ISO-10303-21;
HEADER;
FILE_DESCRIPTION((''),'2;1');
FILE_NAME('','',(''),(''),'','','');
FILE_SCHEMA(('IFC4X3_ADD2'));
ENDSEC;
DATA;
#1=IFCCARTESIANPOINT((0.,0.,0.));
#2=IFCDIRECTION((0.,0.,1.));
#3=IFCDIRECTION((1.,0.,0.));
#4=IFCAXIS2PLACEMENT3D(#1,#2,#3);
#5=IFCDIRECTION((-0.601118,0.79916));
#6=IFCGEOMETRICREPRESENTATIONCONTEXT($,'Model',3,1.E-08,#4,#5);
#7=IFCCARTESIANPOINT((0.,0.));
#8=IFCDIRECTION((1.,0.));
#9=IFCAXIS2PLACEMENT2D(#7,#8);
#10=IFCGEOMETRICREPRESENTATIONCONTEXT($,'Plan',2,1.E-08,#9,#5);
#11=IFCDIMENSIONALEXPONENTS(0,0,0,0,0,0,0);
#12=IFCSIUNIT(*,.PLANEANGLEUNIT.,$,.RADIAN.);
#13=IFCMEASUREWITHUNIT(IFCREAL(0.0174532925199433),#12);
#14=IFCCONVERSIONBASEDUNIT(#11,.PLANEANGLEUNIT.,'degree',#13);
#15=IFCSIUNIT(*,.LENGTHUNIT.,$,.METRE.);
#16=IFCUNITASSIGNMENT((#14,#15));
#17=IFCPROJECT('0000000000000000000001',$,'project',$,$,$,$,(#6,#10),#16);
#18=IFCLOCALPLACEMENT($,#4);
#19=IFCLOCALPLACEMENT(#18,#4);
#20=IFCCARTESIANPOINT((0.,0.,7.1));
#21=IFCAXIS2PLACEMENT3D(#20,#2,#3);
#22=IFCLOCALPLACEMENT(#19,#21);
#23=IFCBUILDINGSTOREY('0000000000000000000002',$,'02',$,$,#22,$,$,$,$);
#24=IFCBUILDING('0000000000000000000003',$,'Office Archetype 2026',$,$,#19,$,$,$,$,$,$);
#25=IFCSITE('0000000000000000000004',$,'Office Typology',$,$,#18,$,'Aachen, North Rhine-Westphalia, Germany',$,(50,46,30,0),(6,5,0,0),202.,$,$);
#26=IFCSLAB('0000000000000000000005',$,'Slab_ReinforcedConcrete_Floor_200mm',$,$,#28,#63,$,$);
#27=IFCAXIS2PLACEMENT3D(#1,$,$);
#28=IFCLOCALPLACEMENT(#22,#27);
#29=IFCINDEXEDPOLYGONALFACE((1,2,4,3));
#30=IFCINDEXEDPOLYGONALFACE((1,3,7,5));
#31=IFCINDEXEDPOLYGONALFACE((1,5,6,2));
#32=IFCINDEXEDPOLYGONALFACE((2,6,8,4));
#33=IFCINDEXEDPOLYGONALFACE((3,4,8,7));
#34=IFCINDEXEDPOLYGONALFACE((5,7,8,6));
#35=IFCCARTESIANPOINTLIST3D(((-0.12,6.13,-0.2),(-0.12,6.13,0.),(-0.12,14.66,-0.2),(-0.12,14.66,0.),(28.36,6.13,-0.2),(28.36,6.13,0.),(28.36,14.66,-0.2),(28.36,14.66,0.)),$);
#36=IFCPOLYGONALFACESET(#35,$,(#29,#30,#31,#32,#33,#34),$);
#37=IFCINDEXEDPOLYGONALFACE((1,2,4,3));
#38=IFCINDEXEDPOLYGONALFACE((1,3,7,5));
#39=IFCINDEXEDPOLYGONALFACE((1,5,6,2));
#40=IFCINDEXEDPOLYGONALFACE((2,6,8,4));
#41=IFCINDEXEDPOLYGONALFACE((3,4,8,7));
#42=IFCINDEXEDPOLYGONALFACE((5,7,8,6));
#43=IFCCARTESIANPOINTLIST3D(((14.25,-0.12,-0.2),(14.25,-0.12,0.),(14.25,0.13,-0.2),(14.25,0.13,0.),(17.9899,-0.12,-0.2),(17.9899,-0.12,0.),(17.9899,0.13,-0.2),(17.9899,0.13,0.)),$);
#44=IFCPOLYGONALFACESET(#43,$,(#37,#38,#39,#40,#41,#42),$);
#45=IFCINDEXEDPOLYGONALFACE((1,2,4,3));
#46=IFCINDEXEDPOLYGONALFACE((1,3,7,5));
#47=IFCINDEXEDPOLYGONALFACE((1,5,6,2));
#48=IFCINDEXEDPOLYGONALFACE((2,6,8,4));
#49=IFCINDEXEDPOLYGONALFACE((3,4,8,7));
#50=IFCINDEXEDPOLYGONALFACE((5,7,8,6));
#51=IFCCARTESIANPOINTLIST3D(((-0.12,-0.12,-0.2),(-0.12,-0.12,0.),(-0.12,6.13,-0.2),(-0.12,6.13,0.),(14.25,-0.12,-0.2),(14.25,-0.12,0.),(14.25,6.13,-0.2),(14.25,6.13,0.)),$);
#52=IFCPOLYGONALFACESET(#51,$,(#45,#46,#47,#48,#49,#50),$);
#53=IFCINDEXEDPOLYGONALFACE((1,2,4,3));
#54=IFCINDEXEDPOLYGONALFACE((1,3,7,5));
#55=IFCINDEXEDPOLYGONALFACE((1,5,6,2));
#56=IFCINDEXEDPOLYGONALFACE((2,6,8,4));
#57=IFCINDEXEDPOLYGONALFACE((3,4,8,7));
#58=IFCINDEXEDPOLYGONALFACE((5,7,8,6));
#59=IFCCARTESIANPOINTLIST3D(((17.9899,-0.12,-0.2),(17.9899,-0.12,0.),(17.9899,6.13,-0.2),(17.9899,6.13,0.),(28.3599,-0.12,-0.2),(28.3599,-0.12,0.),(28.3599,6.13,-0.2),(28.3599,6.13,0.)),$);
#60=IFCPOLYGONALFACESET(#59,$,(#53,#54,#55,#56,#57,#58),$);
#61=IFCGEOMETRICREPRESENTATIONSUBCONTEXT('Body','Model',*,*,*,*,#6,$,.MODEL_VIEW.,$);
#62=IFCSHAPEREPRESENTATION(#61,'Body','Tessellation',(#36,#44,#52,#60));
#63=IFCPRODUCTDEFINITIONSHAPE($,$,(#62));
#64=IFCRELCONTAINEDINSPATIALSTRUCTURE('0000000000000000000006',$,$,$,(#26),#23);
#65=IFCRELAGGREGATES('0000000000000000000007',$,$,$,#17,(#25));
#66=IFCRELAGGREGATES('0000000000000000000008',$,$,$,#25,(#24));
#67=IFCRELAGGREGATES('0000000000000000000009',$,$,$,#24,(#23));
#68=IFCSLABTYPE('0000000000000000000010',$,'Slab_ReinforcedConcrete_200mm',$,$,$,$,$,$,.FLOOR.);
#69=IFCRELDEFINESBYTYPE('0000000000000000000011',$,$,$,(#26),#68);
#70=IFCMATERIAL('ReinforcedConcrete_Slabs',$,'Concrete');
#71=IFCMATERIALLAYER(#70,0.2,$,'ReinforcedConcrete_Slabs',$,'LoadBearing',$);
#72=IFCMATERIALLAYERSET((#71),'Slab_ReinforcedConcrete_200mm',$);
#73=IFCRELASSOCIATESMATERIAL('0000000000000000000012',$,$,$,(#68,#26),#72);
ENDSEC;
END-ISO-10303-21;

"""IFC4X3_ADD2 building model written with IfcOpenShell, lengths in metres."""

from ifc_helpers import new_model, entity, si_unit, converted_unit, direction, frame, origin_with_axes, origin_2d_with_axis, place, context, subcontext, project, spatial, indexed_curve, outline, extrude, material, layer, layer_set, layer_usage, type_object, element, save


model = new_model("IFC4X3_ADD2")

# Units and contexts
model_context = context("Model", 3, precision=1e-08, world=origin_with_axes(), true_north=direction((-0.601118, 0.79916)))
plan_context = context("Plan", 2, precision=1e-08, world=origin_2d_with_axis(), true_north=direction((-0.601118, 0.79916)))
body_context = subcontext(model_context, "Body", "Model", "MODEL_VIEW")
ifc_project = project(units=[converted_unit("PLANEANGLEUNIT", "degree", entity("IfcReal", 0.0174532925199433), si_unit("PLANEANGLEUNIT", "RADIAN"), dimensions=[0, 0, 0, 0, 0, 0, 0]), si_unit("LENGTHUNIT", "METRE")], contexts=[model_context, plan_context])

# Site, building, storey
site_placement = place(None, origin_with_axes())
site = spatial("IfcSite", under=ifc_project, at=site_placement, Name="Office Typology", LongName="Aachen, North Rhine-Westphalia, Germany", RefLatitude=(50, 46, 30, 0), RefLongitude=(6, 5, 0, 0), RefElevation=202.0)
building_placement = place(site_placement, origin_with_axes())
building = spatial("IfcBuilding", under=site, at=building_placement, Name="Office Archetype 2026")
storey_placement = place(building_placement, frame((0.0, 0.0, 7.1), z_axis=(0.0, 0.0, 1.0), x_axis=(1.0, 0.0, 0.0)))
storey = spatial("IfcBuildingStorey", under=building, at=storey_placement, Name="02")

# Slab
ifc_material_1 = material(Name="ReinforcedConcrete_Slabs", Category="Concrete")
ifc_layer_1 = layer(ifc_material_1, 0.2, Name="ReinforcedConcrete_Slabs", Category="LoadBearing")
ifc_layer_set_1 = layer_set([ifc_layer_1], Name="Slab_ReinforcedConcrete_200mm")
slab_type_1 = type_object("IfcSlabType", Name="Slab_ReinforcedConcrete_200mm", PredefinedType="FLOOR", material=ifc_layer_set_1)
ifc_layer_usage_1 = layer_usage(ifc_layer_set_1, "AXIS3", "POSITIVE", 0.0)
slab_1_placement = place(storey_placement, frame((17.9899, 6.13, 0.0), z_axis=(0.0, 0.0, 1.0), x_axis=(1.0, 0.0, 0.0)))
element("IfcSlab", 1, at=slab_1_placement, inside=storey, type_object=slab_type_1, material=ifc_layer_usage_1, Name="Slab_ReinforcedConcrete_Floor_200mm", context=body_context, shape_type="SweptSolid", body=[
    extrude(outline(indexed_curve([(0.0, 0.0), (28.48, 0.0), (28.48, -8.53), (0.0, -8.53), (0.0, 0.0)])), frame((-18.1099, 8.53, -0.2), z_axis=(0.0, 0.0, 1.0), x_axis=(1.0, 0.0, 0.0)), (0.0, 0.0, 1.0), 0.2),
    extrude(outline(indexed_curve([(0.0, 0.0), (3.7399, 0.0), (3.7399, 0.25), (0.0, 0.25), (0.0, 0.0)])), frame((-3.7399, -6.25, -0.2), z_axis=(0.0, 0.0, 1.0), x_axis=(1.0, 0.0, 0.0)), (0.0, 0.0, 1.0), 0.2),
    extrude(outline(indexed_curve([(0.0, 0.0), (14.37, 0.0), (14.37, -6.25), (0.0, -6.25), (0.0, 0.0)])), frame((-18.1099, 0.0, -0.2), z_axis=(0.0, 0.0, 1.0), x_axis=(1.0, 0.0, 0.0)), (0.0, 0.0, 1.0), 0.2),
    extrude(outline(indexed_curve([(0.0, 0.0), (0.0, -6.25), (10.37, -6.25), (10.37, 0.0), (0.0, 0.0)])), frame((0.0, 0.0, -0.2), z_axis=(0.0, 0.0, 1.0), x_axis=(1.0, 0.0, 0.0)), (0.0, 0.0, 1.0), 0.2),
])

save(model, "model.ifc")
